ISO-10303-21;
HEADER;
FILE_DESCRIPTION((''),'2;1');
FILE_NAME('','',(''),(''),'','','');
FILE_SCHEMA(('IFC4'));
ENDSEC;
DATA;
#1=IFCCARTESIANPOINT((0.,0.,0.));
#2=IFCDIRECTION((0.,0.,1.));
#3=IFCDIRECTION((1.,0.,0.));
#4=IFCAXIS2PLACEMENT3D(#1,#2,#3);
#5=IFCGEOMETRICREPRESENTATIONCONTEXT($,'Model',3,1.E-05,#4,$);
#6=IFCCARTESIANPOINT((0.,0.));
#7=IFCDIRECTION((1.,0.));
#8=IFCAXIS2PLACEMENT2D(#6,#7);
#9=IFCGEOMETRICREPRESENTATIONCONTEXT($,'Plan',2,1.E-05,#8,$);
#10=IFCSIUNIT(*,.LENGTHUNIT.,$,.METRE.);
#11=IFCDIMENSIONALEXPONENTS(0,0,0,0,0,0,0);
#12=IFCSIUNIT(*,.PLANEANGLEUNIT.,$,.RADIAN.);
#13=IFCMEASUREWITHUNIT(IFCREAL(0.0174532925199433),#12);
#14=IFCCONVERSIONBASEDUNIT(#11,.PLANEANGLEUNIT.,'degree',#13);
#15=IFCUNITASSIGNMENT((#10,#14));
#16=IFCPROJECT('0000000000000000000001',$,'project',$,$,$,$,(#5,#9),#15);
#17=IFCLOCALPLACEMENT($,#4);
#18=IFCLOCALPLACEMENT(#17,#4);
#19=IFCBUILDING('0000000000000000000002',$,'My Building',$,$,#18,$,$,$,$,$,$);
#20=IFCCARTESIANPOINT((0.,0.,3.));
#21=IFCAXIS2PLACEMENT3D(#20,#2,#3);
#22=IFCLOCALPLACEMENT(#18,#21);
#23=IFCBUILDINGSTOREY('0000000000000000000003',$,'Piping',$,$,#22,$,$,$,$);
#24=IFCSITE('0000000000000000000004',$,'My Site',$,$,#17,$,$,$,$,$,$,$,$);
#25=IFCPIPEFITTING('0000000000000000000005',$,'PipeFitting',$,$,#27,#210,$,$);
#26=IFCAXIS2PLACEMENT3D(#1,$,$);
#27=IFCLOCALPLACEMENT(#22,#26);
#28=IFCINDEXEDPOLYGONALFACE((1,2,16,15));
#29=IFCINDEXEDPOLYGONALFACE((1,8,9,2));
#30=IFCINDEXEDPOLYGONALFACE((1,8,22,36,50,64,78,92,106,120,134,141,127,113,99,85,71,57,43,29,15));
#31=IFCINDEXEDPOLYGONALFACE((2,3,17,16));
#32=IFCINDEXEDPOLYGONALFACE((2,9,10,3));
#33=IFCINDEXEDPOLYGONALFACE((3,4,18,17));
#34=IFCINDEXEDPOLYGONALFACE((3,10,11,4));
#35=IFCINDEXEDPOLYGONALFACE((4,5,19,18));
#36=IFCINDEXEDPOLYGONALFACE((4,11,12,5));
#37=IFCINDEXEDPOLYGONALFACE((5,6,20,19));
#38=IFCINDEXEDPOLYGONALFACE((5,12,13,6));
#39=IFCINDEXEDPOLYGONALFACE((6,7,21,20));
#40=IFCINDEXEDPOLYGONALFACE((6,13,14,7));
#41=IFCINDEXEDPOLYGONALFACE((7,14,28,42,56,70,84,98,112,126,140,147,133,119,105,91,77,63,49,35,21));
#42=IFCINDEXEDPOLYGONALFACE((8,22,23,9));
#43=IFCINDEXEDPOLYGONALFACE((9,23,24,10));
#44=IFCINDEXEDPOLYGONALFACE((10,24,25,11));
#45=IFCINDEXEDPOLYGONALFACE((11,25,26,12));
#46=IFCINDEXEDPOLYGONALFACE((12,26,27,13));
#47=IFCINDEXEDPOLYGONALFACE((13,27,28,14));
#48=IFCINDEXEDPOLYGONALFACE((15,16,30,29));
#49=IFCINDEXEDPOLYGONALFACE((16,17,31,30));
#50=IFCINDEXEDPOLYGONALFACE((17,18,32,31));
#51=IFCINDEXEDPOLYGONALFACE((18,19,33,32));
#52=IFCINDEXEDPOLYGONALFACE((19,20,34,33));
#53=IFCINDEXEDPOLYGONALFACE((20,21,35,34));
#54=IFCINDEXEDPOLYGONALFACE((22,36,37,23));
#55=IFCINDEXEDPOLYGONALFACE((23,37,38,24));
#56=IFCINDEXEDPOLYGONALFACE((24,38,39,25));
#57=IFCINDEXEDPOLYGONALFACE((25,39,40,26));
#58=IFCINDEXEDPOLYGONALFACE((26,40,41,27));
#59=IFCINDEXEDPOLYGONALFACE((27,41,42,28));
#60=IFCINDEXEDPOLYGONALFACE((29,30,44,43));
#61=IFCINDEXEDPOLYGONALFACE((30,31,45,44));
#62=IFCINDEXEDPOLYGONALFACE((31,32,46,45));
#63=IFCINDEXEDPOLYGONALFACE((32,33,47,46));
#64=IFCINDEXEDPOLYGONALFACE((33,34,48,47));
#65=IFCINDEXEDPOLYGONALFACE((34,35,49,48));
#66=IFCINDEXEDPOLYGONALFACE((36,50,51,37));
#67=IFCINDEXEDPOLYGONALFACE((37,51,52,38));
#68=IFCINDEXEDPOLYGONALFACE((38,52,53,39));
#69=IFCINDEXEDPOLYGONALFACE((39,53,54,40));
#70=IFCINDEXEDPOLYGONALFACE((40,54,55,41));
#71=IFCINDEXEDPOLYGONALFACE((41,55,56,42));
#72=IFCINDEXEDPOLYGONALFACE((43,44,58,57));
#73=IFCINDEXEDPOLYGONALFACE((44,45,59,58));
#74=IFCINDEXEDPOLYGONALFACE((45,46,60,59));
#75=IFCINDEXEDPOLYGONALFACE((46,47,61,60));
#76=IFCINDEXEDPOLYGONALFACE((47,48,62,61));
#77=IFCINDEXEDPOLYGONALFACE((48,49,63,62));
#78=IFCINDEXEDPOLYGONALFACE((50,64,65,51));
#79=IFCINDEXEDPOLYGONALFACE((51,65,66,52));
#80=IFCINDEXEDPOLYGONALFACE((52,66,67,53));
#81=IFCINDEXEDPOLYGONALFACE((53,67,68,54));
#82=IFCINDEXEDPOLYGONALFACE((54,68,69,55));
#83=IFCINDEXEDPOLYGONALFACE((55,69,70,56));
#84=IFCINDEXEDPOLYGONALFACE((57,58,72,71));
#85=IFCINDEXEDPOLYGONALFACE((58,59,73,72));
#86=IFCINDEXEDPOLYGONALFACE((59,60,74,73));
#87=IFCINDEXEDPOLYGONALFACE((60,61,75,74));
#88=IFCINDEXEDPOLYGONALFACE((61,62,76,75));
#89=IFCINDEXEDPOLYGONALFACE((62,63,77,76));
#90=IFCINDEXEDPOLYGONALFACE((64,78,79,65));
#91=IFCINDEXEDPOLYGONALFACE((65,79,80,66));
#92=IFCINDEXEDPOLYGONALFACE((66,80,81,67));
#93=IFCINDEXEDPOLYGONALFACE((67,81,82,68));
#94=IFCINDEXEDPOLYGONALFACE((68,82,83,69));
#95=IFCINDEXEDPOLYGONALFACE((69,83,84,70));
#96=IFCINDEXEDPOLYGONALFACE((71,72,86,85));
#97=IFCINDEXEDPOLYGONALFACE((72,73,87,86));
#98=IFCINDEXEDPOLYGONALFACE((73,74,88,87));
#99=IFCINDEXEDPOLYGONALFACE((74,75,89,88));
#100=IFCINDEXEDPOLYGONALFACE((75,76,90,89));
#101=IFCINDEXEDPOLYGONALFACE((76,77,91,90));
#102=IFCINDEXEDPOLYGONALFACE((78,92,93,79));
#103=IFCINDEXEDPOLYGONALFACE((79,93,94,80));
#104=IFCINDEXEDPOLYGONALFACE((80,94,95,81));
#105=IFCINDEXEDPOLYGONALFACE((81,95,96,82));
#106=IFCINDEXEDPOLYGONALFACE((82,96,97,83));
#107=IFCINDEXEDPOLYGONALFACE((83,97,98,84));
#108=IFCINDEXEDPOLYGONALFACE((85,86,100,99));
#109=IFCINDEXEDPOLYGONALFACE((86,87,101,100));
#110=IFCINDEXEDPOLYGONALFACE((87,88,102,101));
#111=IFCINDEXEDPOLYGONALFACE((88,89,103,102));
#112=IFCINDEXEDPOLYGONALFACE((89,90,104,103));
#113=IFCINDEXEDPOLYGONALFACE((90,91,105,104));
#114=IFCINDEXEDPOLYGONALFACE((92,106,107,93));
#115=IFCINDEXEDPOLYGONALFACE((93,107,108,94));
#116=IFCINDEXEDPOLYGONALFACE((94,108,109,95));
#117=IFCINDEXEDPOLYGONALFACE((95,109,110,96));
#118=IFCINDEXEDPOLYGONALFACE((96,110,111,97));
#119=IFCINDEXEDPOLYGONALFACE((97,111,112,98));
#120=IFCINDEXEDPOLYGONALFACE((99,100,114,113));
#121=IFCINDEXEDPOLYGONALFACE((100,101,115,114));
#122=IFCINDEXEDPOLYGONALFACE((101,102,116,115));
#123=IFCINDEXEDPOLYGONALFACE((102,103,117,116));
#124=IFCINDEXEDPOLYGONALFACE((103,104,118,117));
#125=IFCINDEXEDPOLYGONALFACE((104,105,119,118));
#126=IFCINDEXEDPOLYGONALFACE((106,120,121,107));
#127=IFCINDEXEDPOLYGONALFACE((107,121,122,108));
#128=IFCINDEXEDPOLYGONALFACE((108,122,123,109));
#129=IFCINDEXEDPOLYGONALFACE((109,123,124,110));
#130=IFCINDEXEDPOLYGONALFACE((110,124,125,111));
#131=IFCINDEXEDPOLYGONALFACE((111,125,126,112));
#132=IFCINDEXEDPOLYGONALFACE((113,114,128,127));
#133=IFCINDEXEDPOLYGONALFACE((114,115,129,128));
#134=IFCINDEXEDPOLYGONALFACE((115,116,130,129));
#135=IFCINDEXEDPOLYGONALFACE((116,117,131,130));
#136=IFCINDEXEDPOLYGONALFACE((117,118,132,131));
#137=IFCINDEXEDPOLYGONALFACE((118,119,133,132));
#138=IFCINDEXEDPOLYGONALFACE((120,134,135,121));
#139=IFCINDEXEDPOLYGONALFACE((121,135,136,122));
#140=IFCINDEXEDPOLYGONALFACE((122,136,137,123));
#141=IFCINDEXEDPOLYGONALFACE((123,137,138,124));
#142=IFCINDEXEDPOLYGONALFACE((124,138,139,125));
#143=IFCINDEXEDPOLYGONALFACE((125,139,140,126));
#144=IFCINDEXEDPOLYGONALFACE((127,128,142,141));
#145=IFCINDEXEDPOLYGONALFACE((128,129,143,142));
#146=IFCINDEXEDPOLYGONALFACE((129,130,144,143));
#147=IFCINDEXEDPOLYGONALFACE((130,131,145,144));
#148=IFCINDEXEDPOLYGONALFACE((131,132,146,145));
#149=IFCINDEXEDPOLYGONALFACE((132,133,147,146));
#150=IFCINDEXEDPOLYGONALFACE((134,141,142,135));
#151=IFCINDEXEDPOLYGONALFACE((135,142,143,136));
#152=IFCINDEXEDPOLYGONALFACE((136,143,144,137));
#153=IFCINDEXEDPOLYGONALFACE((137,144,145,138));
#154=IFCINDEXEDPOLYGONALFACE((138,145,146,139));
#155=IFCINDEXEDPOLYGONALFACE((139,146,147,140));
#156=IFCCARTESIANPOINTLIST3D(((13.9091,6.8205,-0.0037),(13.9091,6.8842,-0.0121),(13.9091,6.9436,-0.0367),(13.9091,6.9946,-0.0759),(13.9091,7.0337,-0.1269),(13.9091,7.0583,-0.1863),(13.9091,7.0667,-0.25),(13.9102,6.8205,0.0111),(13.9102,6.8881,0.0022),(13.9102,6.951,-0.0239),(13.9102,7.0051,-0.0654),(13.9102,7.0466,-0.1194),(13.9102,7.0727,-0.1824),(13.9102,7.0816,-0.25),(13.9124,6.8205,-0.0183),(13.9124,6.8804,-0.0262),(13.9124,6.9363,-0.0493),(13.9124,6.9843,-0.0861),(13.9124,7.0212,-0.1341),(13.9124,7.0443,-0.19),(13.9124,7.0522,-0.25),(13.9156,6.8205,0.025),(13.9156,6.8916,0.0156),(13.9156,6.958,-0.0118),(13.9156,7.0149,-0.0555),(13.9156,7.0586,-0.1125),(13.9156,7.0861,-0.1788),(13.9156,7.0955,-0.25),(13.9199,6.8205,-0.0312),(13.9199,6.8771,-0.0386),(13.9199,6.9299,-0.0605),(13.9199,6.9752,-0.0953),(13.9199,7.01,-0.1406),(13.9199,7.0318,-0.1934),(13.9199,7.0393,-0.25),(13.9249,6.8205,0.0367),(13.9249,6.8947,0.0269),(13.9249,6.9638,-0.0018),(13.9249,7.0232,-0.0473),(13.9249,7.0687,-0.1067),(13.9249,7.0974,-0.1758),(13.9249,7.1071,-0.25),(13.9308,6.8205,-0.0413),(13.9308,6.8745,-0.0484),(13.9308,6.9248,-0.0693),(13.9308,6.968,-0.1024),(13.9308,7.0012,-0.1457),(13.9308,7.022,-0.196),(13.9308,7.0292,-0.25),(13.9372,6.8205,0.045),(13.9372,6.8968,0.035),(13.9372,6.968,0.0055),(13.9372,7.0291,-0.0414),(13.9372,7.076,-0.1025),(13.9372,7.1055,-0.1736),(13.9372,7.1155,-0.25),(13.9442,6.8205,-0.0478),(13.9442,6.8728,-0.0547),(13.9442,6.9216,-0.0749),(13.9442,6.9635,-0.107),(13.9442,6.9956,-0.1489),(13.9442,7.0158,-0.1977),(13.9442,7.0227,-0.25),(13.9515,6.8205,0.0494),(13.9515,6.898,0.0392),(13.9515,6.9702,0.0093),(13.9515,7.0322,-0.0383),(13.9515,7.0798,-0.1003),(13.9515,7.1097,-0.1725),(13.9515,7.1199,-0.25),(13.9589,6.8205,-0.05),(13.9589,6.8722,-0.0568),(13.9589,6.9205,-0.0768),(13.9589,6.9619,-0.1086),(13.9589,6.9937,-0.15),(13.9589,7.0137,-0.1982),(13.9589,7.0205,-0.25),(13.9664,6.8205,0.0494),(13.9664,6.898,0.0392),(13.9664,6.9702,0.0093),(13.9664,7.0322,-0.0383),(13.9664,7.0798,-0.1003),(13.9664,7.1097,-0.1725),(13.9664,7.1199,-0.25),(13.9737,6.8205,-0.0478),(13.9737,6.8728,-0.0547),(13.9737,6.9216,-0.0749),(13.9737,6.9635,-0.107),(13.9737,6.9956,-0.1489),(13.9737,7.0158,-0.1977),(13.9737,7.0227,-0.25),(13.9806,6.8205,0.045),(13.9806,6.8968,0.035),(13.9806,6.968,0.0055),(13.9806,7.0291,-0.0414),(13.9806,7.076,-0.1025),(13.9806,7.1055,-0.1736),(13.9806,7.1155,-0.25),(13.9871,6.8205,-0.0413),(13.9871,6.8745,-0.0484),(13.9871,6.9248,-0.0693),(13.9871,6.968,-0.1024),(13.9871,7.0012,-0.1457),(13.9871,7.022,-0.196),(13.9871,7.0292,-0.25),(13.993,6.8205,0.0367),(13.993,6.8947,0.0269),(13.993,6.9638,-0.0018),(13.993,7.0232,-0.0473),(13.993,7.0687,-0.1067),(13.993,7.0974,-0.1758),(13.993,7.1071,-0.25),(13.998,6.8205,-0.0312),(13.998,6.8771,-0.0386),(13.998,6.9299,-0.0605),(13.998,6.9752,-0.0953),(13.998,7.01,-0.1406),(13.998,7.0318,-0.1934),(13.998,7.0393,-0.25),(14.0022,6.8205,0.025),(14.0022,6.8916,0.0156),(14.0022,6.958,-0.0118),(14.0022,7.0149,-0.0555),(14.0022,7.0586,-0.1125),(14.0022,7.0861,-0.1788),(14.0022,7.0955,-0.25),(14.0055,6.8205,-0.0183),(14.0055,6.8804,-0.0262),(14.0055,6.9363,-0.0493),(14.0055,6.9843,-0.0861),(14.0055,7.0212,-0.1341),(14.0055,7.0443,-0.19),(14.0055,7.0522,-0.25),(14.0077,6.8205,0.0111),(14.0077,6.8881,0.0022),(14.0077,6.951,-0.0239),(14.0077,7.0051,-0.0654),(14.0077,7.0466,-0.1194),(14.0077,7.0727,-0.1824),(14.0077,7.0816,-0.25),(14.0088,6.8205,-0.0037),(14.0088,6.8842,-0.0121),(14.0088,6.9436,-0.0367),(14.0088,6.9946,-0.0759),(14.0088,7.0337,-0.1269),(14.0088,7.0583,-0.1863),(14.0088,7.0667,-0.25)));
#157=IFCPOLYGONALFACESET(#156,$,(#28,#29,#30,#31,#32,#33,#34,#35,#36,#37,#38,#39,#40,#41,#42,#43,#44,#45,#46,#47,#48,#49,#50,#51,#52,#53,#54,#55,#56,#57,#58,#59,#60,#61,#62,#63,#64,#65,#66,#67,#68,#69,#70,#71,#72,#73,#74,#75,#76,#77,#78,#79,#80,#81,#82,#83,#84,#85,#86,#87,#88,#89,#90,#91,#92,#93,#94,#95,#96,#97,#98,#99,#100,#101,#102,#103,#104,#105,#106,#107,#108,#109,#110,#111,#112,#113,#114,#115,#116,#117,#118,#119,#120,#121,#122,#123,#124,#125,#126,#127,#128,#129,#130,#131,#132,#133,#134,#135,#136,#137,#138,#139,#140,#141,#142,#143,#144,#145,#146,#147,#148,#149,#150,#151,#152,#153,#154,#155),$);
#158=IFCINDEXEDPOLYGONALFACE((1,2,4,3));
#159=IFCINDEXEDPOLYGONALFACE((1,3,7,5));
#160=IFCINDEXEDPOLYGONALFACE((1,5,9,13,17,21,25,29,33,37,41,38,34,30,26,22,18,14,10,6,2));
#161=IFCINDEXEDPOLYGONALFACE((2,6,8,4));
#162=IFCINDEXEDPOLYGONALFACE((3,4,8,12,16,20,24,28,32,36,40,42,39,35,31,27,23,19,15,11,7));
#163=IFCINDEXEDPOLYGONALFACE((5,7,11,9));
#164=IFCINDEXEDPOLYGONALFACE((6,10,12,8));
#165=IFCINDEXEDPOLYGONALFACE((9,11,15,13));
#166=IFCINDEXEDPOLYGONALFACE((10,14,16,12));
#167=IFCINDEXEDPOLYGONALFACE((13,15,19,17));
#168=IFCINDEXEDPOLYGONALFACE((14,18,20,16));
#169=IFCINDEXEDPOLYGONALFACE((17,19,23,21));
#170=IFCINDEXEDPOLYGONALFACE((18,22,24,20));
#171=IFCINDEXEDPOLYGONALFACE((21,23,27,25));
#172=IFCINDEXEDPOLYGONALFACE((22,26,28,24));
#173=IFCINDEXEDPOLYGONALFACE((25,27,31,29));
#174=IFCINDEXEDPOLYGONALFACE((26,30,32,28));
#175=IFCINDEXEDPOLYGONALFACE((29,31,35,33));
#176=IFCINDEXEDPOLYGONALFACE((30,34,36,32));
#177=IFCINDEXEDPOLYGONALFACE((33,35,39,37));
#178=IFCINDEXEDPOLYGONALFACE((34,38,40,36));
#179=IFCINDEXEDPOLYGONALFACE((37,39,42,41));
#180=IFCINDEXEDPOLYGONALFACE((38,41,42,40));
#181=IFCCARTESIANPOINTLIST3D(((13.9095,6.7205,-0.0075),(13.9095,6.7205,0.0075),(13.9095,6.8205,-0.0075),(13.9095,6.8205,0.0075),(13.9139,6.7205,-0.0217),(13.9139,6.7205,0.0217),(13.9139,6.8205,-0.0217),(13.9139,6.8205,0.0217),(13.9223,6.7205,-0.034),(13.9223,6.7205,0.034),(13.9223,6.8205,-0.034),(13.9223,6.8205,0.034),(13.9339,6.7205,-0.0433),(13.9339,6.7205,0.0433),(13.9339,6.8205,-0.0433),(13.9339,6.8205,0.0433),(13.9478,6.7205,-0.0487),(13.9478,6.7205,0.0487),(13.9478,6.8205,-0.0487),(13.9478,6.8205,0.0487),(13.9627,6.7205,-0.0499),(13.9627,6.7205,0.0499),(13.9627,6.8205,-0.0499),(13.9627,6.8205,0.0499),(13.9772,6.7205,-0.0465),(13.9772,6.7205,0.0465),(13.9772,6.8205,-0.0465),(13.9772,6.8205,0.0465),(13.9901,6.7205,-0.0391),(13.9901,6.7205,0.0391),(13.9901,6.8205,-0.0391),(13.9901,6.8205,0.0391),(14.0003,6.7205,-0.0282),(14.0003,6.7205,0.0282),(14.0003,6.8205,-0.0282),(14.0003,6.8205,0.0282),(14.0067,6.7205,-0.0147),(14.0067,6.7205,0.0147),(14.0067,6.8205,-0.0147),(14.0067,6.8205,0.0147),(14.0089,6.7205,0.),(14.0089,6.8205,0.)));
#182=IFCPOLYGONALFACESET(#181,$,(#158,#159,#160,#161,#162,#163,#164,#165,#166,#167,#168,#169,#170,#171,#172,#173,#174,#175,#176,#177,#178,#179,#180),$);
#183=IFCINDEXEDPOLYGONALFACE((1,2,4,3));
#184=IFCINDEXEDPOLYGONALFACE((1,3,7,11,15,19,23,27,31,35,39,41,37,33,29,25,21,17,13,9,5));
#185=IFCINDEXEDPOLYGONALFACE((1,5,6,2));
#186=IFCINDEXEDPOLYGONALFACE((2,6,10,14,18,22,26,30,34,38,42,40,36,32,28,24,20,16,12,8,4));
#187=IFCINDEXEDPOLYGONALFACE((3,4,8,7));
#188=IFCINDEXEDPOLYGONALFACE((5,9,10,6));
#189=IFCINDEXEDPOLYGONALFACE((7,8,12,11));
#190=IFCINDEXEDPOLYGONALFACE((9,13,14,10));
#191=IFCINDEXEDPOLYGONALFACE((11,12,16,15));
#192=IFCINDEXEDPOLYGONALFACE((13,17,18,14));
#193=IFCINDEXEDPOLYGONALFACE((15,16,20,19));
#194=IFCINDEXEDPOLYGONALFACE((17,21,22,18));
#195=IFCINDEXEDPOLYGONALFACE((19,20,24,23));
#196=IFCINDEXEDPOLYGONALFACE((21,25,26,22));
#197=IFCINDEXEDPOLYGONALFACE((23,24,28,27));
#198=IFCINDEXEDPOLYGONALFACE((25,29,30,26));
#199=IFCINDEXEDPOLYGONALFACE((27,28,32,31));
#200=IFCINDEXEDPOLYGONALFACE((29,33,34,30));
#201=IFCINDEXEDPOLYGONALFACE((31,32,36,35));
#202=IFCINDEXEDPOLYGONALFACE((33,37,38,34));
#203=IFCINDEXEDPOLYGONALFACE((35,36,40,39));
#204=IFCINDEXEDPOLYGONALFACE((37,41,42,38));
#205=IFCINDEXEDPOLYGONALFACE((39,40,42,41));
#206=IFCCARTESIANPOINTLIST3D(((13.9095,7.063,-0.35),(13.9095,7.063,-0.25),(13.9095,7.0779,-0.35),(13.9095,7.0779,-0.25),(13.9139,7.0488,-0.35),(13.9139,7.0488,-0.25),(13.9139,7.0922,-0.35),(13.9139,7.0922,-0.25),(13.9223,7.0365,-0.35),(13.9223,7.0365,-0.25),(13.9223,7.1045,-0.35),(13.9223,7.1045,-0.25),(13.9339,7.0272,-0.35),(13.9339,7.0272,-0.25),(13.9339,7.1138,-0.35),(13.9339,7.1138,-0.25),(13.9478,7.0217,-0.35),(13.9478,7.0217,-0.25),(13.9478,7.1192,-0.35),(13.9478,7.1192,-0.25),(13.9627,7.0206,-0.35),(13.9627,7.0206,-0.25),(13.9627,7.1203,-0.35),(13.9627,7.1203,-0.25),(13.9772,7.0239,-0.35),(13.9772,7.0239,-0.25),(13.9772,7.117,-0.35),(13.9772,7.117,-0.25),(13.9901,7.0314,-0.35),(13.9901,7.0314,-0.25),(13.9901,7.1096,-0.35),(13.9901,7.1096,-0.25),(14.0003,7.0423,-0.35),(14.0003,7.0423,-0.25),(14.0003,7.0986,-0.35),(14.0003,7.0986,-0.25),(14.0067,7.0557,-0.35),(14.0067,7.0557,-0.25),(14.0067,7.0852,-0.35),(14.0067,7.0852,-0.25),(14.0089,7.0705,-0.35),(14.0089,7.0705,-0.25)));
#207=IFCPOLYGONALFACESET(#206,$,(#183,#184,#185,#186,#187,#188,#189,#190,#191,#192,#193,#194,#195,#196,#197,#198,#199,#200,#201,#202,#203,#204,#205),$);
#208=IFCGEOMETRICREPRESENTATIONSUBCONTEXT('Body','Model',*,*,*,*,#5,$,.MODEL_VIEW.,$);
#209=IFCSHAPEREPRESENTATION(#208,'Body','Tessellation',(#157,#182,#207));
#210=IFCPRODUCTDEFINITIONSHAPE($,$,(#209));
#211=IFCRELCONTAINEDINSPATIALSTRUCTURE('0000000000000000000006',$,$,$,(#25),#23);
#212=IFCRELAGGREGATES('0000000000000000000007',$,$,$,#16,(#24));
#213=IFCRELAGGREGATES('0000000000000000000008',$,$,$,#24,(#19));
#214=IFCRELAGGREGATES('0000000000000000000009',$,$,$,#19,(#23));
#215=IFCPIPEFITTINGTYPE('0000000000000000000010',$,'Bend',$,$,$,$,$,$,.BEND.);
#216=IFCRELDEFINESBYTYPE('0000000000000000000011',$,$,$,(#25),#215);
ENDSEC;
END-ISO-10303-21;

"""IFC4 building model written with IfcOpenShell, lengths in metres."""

from ifc_helpers import new_model, entity, si_unit, converted_unit, frame, origin_with_axes, origin_2d_with_axis, place, context, subcontext, project, spatial, circle, extrude, source, transform, mapped, type_object, type_shapes, element, save


model = new_model("IFC4")

# Units and contexts
model_context = context("Model", 3, precision=1e-05, world=origin_with_axes())
plan_context = context("Plan", 2, precision=1e-05, world=origin_2d_with_axis())
body_context = subcontext(model_context, "Body", "Model", "MODEL_VIEW")
ifc_project = project(units=[si_unit("LENGTHUNIT", "METRE"), converted_unit("PLANEANGLEUNIT", "degree", entity("IfcReal", 0.0174532925199433), si_unit("PLANEANGLEUNIT", "RADIAN"), dimensions=[0, 0, 0, 0, 0, 0, 0])], contexts=[model_context, plan_context])

# Site, building, storey
site_placement = place(None, origin_with_axes())
site = spatial("IfcSite", under=ifc_project, at=site_placement, Name="My Site")
building_placement = place(site_placement, origin_with_axes())
building = spatial("IfcBuilding", under=site, at=building_placement, Name="My Building")
storey_placement = place(building_placement, frame((0.0, 0.0, 3.0), z_axis=(0.0, 0.0, 1.0), x_axis=(1.0, 0.0, 0.0)))
storey = spatial("IfcBuildingStorey", under=building, at=storey_placement, Name="Piping")

# Pipe fitting
pipe_fitting_type = type_object("IfcPipeFittingType", Name="Bend", PredefinedType="BEND")
shared_shape = source(origin_with_axes(), body_context, "Body", "SolidModel", [
    entity("IfcSweptDiskSolid", entity("IfcIndexedPolyCurve", entity("IfcCartesianPointList3D", [[0.0, 0.0, -0.1], [0.0, -0.0732, -0.2768], [0.0, -0.25, -0.35]]), [entity("IfcArcIndex", [1, 2, 3])]), 0.05),
    extrude(circle(Radius=0.05), origin_with_axes(), (0.0, 0.0, -1.0), 0.1),
    extrude(circle(Radius=0.05), frame((0.0, -0.25, -0.35), z_axis=(0.0, -1.0, 0.0), x_axis=(1.0, 0.0, 0.0)), (0.0, 0.0, 1.0), 0.1),
])
type_shapes(pipe_fitting_type, [shared_shape])
for number, where, z_axis, x_axis, name in (
    (1, (13.9589, 6.7205, 0.0), (0.0, -1.0, 0.0), (1.0, 0.0, 0.0), "PipeFitting"),
):
    element("IfcPipeFitting", number, at=place(storey_placement, frame(where, z_axis=z_axis, x_axis=x_axis)), inside=storey, type_object=pipe_fitting_type, Name=name, context=body_context, shape_type="MappedRepresentation", body=[
        mapped(shared_shape, transform((0.0, 0.0, 0.0), x_axis=(1.0, 0.0, 0.0), y_axis=(0.0, 1.0, 0.0), z_axis=(0.0, 0.0, 1.0), scale=1.0)),
    ])

save(model, "model.ifc")
